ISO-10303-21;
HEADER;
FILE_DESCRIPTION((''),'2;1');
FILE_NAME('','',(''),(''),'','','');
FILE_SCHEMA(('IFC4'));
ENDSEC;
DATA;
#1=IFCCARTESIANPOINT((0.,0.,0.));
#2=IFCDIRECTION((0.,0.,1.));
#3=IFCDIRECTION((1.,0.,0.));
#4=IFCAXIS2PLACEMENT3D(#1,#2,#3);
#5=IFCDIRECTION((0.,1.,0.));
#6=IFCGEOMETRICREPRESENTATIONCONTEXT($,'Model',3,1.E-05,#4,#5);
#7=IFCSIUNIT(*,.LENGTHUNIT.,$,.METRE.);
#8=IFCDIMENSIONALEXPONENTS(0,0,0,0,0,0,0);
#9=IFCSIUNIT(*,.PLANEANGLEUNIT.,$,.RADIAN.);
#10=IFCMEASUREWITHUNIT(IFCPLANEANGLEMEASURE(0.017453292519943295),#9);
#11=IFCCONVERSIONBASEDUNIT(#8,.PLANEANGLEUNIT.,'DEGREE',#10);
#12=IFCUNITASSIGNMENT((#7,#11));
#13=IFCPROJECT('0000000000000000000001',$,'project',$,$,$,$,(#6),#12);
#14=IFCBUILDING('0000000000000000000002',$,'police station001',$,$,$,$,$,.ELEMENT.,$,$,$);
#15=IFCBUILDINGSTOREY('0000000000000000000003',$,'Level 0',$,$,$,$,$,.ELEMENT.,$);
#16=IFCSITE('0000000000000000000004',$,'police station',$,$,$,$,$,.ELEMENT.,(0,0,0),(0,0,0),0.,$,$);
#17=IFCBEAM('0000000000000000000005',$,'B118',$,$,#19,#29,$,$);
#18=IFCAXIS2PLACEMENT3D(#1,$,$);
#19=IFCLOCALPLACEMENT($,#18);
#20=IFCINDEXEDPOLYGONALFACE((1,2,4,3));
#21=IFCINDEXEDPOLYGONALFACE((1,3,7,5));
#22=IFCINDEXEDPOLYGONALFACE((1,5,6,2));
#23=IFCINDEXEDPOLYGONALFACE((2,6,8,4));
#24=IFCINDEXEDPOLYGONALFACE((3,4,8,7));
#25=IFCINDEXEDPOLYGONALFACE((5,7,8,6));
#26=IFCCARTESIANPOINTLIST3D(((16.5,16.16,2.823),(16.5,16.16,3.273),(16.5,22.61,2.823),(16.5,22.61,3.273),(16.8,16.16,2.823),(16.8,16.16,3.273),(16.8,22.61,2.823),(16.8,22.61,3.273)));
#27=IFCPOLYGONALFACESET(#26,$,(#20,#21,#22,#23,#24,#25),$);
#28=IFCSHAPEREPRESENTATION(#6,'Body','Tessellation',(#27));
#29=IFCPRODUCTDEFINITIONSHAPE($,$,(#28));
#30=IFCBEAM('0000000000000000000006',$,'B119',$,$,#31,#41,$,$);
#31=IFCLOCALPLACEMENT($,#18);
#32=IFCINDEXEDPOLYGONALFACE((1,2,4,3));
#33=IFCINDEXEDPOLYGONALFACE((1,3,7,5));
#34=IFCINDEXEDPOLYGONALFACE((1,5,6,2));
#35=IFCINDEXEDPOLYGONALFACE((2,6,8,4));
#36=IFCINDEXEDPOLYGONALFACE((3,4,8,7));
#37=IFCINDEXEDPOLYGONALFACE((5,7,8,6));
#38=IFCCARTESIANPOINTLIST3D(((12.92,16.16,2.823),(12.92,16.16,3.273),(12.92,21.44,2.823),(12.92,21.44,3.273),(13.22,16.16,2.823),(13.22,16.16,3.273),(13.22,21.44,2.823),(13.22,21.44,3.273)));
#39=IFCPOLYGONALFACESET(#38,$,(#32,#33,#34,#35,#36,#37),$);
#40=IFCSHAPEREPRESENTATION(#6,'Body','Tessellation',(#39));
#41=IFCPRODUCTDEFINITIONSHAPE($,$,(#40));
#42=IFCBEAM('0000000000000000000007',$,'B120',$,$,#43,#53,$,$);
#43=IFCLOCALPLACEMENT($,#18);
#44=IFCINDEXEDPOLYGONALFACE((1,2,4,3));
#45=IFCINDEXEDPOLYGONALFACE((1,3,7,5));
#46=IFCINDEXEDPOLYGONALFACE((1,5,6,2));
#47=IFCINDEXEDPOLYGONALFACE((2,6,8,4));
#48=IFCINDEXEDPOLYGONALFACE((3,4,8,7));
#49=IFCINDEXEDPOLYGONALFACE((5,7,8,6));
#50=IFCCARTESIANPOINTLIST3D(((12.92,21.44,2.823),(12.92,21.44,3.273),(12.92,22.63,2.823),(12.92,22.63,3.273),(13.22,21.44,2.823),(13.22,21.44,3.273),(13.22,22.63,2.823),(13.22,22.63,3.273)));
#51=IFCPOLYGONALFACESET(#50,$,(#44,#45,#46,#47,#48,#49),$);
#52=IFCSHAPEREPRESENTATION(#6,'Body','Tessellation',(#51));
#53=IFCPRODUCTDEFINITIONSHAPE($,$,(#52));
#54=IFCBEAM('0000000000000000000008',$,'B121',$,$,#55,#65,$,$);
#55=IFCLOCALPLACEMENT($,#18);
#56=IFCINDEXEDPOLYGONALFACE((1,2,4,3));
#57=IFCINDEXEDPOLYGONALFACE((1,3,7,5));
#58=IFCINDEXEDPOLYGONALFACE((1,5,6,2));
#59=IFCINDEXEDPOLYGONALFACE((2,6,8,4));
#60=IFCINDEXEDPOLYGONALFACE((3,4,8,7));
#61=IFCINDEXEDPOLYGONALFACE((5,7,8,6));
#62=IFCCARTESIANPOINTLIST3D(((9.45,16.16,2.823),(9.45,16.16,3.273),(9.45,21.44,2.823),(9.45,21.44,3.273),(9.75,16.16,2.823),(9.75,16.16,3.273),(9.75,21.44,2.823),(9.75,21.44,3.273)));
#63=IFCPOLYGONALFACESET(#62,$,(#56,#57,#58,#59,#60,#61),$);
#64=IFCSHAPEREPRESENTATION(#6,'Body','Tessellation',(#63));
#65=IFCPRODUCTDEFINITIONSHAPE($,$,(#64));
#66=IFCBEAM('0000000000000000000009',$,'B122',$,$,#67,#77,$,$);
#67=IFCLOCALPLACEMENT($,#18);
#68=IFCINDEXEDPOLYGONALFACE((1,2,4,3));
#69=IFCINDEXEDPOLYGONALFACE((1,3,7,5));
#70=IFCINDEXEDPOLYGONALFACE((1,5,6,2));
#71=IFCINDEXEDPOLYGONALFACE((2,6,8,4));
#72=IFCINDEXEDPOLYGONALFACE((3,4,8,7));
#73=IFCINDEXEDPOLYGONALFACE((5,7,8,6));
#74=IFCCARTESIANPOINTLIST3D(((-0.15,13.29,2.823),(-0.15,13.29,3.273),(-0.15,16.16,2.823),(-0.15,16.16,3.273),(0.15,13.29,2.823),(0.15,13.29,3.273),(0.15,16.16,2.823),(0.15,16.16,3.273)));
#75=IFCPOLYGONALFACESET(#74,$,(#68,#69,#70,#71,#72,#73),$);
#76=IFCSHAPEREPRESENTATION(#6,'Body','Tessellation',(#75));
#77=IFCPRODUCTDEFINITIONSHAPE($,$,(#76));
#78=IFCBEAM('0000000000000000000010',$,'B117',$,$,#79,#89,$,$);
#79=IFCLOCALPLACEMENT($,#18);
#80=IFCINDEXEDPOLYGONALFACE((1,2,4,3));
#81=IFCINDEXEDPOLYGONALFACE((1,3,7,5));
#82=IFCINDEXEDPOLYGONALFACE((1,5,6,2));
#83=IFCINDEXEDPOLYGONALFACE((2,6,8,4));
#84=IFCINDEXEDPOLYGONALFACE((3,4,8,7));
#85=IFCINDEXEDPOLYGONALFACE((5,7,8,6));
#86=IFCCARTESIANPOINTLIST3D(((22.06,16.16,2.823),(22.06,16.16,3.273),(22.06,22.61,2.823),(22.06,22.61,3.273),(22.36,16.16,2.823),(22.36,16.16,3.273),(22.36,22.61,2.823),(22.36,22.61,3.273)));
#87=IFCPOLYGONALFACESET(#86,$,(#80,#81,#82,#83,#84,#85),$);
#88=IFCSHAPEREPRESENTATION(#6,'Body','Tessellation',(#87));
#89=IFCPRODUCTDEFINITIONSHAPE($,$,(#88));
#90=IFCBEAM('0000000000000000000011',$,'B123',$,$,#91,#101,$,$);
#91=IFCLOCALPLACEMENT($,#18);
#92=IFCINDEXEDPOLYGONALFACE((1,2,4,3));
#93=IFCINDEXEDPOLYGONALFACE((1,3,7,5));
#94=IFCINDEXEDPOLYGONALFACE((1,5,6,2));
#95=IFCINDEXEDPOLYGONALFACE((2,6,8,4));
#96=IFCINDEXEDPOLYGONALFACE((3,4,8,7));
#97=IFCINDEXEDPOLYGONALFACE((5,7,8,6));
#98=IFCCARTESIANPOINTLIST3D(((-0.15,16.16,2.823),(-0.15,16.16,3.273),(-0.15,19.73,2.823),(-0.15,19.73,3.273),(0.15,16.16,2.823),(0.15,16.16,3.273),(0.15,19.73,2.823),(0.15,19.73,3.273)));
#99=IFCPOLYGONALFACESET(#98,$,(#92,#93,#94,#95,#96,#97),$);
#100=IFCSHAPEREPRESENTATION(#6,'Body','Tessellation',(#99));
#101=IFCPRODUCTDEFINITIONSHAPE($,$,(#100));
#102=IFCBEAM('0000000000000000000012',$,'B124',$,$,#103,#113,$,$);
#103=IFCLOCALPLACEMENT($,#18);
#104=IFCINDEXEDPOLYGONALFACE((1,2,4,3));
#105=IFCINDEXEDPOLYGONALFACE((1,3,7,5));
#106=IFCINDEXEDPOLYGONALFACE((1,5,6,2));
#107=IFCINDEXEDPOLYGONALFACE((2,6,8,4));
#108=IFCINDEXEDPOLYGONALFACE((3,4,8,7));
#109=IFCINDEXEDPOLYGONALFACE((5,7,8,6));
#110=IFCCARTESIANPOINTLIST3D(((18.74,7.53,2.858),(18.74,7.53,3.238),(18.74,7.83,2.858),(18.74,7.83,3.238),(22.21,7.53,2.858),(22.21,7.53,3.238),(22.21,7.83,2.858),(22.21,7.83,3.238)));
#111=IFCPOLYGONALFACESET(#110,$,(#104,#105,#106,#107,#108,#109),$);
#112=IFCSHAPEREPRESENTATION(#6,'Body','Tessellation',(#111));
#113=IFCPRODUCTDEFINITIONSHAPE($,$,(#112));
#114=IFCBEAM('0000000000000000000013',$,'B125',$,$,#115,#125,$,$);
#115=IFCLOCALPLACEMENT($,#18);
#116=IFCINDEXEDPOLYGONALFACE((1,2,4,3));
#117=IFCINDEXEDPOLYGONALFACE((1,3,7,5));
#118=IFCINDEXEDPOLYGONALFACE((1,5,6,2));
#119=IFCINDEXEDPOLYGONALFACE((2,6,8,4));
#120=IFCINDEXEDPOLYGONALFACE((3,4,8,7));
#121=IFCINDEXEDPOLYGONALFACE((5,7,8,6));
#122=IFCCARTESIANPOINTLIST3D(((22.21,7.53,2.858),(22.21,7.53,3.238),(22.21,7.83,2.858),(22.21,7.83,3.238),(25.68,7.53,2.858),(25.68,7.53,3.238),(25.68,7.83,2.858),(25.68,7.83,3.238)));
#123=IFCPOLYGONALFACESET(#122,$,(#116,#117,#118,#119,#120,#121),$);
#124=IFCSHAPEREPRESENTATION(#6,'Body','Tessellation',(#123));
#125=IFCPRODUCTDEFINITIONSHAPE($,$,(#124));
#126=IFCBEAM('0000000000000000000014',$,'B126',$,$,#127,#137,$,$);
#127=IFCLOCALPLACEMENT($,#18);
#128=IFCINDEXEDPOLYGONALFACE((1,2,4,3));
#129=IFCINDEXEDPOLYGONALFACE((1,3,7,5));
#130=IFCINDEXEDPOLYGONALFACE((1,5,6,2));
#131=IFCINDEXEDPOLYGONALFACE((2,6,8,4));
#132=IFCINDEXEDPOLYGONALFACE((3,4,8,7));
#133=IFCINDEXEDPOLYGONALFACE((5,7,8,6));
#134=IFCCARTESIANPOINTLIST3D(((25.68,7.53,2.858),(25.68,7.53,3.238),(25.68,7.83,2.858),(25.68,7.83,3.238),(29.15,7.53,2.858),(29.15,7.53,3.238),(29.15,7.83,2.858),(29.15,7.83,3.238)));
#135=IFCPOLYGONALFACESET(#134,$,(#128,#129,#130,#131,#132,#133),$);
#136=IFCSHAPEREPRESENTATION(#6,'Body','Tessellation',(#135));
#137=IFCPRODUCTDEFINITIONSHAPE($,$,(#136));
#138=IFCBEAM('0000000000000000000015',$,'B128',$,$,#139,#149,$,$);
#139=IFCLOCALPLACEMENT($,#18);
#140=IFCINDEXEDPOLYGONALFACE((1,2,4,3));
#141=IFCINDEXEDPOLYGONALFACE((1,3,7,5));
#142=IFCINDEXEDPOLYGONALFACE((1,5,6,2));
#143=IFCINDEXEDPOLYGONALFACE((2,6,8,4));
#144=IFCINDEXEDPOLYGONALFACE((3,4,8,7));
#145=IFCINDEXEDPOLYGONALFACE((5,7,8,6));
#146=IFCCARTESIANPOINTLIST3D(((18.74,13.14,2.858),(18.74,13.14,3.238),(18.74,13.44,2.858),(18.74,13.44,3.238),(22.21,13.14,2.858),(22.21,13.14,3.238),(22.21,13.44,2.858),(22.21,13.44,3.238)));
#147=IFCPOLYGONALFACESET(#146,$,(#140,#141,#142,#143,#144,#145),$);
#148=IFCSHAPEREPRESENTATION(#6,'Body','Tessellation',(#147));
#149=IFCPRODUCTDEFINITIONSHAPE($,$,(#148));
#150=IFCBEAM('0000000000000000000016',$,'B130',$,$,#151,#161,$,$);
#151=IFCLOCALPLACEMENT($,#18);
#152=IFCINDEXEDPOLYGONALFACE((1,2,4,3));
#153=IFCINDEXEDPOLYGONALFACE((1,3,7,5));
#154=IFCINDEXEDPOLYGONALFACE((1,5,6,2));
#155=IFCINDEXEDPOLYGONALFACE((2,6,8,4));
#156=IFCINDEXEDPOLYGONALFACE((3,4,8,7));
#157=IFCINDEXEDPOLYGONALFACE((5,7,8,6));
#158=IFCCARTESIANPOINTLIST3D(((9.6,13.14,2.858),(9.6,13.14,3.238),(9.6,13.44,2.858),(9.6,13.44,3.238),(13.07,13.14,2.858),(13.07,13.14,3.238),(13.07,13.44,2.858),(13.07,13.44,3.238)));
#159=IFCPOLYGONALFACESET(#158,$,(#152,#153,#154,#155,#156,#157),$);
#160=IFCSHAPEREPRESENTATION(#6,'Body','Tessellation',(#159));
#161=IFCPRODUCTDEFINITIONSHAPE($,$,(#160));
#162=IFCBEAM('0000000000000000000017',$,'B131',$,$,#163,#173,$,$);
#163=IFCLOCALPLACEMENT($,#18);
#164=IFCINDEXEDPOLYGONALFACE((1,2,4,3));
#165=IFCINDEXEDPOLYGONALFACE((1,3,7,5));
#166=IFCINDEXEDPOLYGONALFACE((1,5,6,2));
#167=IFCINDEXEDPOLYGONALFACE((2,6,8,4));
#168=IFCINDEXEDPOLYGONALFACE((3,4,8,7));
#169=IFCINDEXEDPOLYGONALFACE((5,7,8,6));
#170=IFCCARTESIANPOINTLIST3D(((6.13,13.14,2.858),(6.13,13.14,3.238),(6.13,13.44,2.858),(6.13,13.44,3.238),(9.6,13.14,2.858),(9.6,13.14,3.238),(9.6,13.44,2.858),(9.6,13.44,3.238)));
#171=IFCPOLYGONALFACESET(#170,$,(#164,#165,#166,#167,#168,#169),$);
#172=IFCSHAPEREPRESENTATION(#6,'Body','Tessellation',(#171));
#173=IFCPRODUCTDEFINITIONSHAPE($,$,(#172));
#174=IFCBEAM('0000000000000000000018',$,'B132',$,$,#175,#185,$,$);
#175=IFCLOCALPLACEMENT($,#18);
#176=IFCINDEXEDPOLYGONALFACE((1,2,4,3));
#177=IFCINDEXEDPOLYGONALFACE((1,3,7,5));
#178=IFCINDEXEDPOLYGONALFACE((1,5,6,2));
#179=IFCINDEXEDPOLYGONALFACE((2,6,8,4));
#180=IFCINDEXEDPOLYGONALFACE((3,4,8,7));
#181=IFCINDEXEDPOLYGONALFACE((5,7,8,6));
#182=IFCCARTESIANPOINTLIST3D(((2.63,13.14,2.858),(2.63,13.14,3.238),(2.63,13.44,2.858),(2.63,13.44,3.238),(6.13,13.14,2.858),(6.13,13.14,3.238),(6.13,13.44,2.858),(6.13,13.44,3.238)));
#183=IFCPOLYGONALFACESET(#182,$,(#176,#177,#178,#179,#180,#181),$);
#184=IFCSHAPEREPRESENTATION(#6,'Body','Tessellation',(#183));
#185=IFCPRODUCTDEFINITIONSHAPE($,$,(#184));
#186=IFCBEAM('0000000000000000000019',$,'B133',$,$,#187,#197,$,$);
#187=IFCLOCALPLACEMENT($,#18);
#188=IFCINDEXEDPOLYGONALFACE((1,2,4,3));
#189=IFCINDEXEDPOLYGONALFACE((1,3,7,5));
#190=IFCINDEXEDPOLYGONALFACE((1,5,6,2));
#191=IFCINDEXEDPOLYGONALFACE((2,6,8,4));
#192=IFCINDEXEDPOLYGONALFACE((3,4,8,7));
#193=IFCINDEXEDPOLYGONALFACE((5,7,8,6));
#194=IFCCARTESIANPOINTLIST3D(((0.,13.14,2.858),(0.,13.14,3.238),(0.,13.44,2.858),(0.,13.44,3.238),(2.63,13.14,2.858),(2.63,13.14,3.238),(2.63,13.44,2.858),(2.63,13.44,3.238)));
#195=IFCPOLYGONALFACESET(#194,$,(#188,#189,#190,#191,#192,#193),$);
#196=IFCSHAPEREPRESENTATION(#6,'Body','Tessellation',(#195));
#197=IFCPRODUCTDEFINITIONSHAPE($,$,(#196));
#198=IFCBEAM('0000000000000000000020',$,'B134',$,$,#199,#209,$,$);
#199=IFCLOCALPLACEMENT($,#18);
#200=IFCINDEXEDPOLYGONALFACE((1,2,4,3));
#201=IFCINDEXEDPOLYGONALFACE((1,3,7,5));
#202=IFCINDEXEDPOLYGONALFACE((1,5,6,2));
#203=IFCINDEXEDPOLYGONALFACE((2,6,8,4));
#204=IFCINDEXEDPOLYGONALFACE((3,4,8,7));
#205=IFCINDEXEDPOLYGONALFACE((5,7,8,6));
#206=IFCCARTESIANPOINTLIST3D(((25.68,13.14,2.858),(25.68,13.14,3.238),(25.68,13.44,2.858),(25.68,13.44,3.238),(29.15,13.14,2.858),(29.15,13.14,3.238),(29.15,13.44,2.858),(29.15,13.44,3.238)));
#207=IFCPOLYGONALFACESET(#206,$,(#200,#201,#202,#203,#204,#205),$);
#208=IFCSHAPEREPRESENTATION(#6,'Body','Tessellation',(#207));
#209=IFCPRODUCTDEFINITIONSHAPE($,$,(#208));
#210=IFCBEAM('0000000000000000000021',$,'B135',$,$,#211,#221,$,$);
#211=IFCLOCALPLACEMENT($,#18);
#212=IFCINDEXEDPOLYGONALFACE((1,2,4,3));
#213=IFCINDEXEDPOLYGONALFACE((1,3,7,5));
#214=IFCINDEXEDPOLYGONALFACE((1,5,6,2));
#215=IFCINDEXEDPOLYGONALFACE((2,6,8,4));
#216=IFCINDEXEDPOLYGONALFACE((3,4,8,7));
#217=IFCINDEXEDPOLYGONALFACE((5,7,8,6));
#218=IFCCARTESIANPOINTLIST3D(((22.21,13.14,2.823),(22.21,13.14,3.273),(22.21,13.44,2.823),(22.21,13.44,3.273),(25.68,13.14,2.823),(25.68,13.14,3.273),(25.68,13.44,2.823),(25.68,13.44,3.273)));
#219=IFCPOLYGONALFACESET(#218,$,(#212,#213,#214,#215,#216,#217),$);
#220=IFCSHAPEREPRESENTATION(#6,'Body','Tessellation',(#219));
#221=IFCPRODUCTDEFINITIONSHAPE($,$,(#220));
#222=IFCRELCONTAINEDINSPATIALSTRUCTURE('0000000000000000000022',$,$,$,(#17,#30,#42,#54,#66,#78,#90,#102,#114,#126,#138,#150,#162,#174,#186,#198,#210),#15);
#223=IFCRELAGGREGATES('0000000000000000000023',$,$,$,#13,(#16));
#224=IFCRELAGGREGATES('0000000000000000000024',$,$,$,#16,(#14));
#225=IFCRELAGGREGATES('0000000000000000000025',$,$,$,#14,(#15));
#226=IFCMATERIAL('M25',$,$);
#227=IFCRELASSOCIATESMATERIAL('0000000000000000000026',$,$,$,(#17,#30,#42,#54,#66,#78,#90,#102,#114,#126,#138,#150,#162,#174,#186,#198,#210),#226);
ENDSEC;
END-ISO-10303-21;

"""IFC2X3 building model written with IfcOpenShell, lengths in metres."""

from ifc_helpers import new_model, entity, si_unit, converted_unit, direction, frame, frame_2d, origin_with_axes, place, context, project, spatial, rectangle, extrude, material, element, save


model = new_model("IFC2X3")

# Units and contexts
model_context = context("Model", 3, precision=1e-05, world=origin_with_axes(), true_north=direction((0.0, 1.0, 0.0)))
ifc_project = project(units=[si_unit("LENGTHUNIT", "METRE"), converted_unit("PLANEANGLEUNIT", "DEGREE", entity("IfcPlaneAngleMeasure", 0.017453292519943295), si_unit("PLANEANGLEUNIT", "RADIAN"), dimensions=[0, 0, 0, 0, 0, 0, 0])], contexts=[model_context])

# Site, building, storey
site = spatial("IfcSite", under=ifc_project, Name="police station", CompositionType="ELEMENT", RefLatitude=(0, 0, 0), RefLongitude=(0, 0, 0), RefElevation=0.0)
building = spatial("IfcBuilding", under=site, Name="police station001", CompositionType="ELEMENT")
storey = spatial("IfcBuildingStorey", under=building, Name="Level 0", CompositionType="ELEMENT")

# Beams
ifc_material = material(Name="M25")
placement = place(None, origin_with_axes())
element("IfcBeam", 1, at=placement, inside=storey, material=ifc_material, Name="B118", context=model_context, shape_type="SweptSolid", body=[
    extrude(rectangle(XDim=0.3, YDim=0.45, at=frame_2d((0.0, 0.0), x_axis=(0.0, 1.0, 0.0))), frame((16.65, 16.16, 3.048), z_axis=(0.0, 1.0, 0.0), x_axis=(0.0, 0.0, -1.0)), (0.0, 0.0, 1.0), 6.45),
])
element("IfcBeam", 2, at=placement, inside=storey, material=ifc_material, Name="B119", context=model_context, shape_type="SweptSolid", body=[
    extrude(rectangle(XDim=0.3, YDim=0.45, at=frame_2d((0.0, 0.0), x_axis=(0.0, 1.0, 0.0))), frame((13.07, 16.16, 3.048), z_axis=(0.0, 1.0, 0.0), x_axis=(0.0, 0.0, -1.0)), (0.0, 0.0, 1.0), 5.28),
])
element("IfcBeam", 3, at=placement, inside=storey, material=ifc_material, Name="B120", context=model_context, shape_type="SweptSolid", body=[
    extrude(rectangle(XDim=0.3, YDim=0.45, at=frame_2d((0.0, 0.0), x_axis=(0.0, 1.0, 0.0))), frame((13.07, 21.44, 3.048), z_axis=(0.0, 1.0, 0.0), x_axis=(0.0, 0.0, -1.0)), (0.0, 0.0, 1.0), 1.19),
])
element("IfcBeam", 4, at=placement, inside=storey, material=ifc_material, Name="B121", context=model_context, shape_type="SweptSolid", body=[
    extrude(rectangle(XDim=0.3, YDim=0.45, at=frame_2d((0.0, 0.0), x_axis=(0.0, 1.0, 0.0))), frame((9.6, 16.16, 3.048), z_axis=(0.0, 1.0, 0.0), x_axis=(0.0, 0.0, -1.0)), (0.0, 0.0, 1.0), 5.28),
])
element("IfcBeam", 5, at=placement, inside=storey, material=ifc_material, Name="B122", context=model_context, shape_type="SweptSolid", body=[
    extrude(rectangle(XDim=0.3, YDim=0.45, at=frame_2d((0.0, 0.0), x_axis=(0.0, 1.0, 0.0))), frame((0.0, 13.29, 3.048), z_axis=(0.0, 1.0, 0.0), x_axis=(0.0, 0.0, -1.0)), (0.0, 0.0, 1.0), 2.87),
])
element("IfcBeam", 6, at=placement, inside=storey, material=ifc_material, Name="B117", context=model_context, shape_type="SweptSolid", body=[
    extrude(rectangle(XDim=0.3, YDim=0.45, at=frame_2d((0.0, 0.0), x_axis=(0.0, 1.0, 0.0))), frame((22.21, 16.16, 3.048), z_axis=(0.0, 1.0, 0.0), x_axis=(0.0, 0.0, -1.0)), (0.0, 0.0, 1.0), 6.45),
])
element("IfcBeam", 7, at=placement, inside=storey, material=ifc_material, Name="B123", context=model_context, shape_type="SweptSolid", body=[
    extrude(rectangle(XDim=0.3, YDim=0.45, at=frame_2d((0.0, 0.0), x_axis=(0.0, 1.0, 0.0))), frame((0.0, 19.73, 3.048), z_axis=(0.0, -1.0, 0.0), x_axis=(0.0, 0.0, -1.0)), (0.0, 0.0, 1.0), 3.57),
])
element("IfcBeam", 8, at=placement, inside=storey, material=ifc_material, Name="B124", context=model_context, shape_type="SweptSolid", body=[
    extrude(rectangle(XDim=0.3, YDim=0.38, at=frame_2d((0.0, 0.0), x_axis=(0.0, 1.0, 0.0))), frame((18.74, 7.68, 3.048), z_axis=(1.0, 0.0, 0.0), x_axis=(0.0, 0.0, -1.0)), (0.0, 0.0, 1.0), 3.47),
])
element("IfcBeam", 9, at=placement, inside=storey, material=ifc_material, Name="B125", context=model_context, shape_type="SweptSolid", body=[
    extrude(rectangle(XDim=0.3, YDim=0.38, at=frame_2d((0.0, 0.0), x_axis=(0.0, 1.0, 0.0))), frame((25.68, 7.68, 3.048), z_axis=(-1.0, 0.0, 0.0), x_axis=(0.0, 0.0, -1.0)), (0.0, 0.0, 1.0), 3.47),
])
element("IfcBeam", 10, at=placement, inside=storey, material=ifc_material, Name="B126", context=model_context, shape_type="SweptSolid", body=[
    extrude(rectangle(XDim=0.3, YDim=0.38, at=frame_2d((0.0, 0.0), x_axis=(0.0, 1.0, 0.0))), frame((25.68, 7.68, 3.048), z_axis=(1.0, 0.0, 0.0), x_axis=(0.0, 0.0, -1.0)), (0.0, 0.0, 1.0), 3.47),
])
element("IfcBeam", 11, at=placement, inside=storey, material=ifc_material, Name="B128", context=model_context, shape_type="SweptSolid", body=[
    extrude(rectangle(XDim=0.3, YDim=0.38, at=frame_2d((0.0, 0.0), x_axis=(0.0, 1.0, 0.0))), frame((22.21, 13.29, 3.048), z_axis=(-1.0, 0.0, 0.0), x_axis=(0.0, 0.0, -1.0)), (0.0, 0.0, 1.0), 3.47),
])
element("IfcBeam", 12, at=placement, inside=storey, material=ifc_material, Name="B130", context=model_context, shape_type="SweptSolid", body=[
    extrude(rectangle(XDim=0.3, YDim=0.38, at=frame_2d((0.0, 0.0), x_axis=(0.0, 1.0, 0.0))), frame((13.07, 13.29, 3.048), z_axis=(-1.0, 0.0, 0.0), x_axis=(0.0, 0.0, -1.0)), (0.0, 0.0, 1.0), 3.47),
])
element("IfcBeam", 13, at=placement, inside=storey, material=ifc_material, Name="B131", context=model_context, shape_type="SweptSolid", body=[
    extrude(rectangle(XDim=0.3, YDim=0.38, at=frame_2d((0.0, 0.0), x_axis=(0.0, 1.0, 0.0))), frame((9.6, 13.29, 3.048), z_axis=(-1.0, 0.0, 0.0), x_axis=(0.0, 0.0, -1.0)), (0.0, 0.0, 1.0), 3.47),
])
element("IfcBeam", 14, at=placement, inside=storey, material=ifc_material, Name="B132", context=model_context, shape_type="SweptSolid", body=[
    extrude(rectangle(XDim=0.3, YDim=0.38, at=frame_2d((0.0, 0.0), x_axis=(0.0, 1.0, 0.0))), frame((2.63, 13.29, 3.048), z_axis=(1.0, 0.0, 0.0), x_axis=(0.0, 0.0, -1.0)), (0.0, 0.0, 1.0), 3.5),
])
element("IfcBeam", 15, at=placement, inside=storey, material=ifc_material, Name="B133", context=model_context, shape_type="SweptSolid", body=[
    extrude(rectangle(XDim=0.3, YDim=0.38, at=frame_2d((0.0, 0.0), x_axis=(0.0, 1.0, 0.0))), frame((0.0, 13.29, 3.048), z_axis=(1.0, 0.0, 0.0), x_axis=(0.0, 0.0, -1.0)), (0.0, 0.0, 1.0), 2.63),
])
element("IfcBeam", 16, at=placement, inside=storey, material=ifc_material, Name="B134", context=model_context, shape_type="SweptSolid", body=[
    extrude(rectangle(XDim=0.3, YDim=0.38, at=frame_2d((0.0, 0.0), x_axis=(0.0, 1.0, 0.0))), frame((29.15, 13.29, 3.048), z_axis=(-1.0, 0.0, 0.0), x_axis=(0.0, 0.0, -1.0)), (0.0, 0.0, 1.0), 3.47),
])
element("IfcBeam", 17, at=placement, inside=storey, material=ifc_material, Name="B135", context=model_context, shape_type="SweptSolid", body=[
    extrude(rectangle(XDim=0.3, YDim=0.45, at=frame_2d((0.0, 0.0), x_axis=(0.0, 1.0, 0.0))), frame((25.68, 13.29, 3.048), z_axis=(-1.0, 0.0, 0.0), x_axis=(0.0, 0.0, -1.0)), (0.0, 0.0, 1.0), 3.47),
])

save(model, "model.ifc")
